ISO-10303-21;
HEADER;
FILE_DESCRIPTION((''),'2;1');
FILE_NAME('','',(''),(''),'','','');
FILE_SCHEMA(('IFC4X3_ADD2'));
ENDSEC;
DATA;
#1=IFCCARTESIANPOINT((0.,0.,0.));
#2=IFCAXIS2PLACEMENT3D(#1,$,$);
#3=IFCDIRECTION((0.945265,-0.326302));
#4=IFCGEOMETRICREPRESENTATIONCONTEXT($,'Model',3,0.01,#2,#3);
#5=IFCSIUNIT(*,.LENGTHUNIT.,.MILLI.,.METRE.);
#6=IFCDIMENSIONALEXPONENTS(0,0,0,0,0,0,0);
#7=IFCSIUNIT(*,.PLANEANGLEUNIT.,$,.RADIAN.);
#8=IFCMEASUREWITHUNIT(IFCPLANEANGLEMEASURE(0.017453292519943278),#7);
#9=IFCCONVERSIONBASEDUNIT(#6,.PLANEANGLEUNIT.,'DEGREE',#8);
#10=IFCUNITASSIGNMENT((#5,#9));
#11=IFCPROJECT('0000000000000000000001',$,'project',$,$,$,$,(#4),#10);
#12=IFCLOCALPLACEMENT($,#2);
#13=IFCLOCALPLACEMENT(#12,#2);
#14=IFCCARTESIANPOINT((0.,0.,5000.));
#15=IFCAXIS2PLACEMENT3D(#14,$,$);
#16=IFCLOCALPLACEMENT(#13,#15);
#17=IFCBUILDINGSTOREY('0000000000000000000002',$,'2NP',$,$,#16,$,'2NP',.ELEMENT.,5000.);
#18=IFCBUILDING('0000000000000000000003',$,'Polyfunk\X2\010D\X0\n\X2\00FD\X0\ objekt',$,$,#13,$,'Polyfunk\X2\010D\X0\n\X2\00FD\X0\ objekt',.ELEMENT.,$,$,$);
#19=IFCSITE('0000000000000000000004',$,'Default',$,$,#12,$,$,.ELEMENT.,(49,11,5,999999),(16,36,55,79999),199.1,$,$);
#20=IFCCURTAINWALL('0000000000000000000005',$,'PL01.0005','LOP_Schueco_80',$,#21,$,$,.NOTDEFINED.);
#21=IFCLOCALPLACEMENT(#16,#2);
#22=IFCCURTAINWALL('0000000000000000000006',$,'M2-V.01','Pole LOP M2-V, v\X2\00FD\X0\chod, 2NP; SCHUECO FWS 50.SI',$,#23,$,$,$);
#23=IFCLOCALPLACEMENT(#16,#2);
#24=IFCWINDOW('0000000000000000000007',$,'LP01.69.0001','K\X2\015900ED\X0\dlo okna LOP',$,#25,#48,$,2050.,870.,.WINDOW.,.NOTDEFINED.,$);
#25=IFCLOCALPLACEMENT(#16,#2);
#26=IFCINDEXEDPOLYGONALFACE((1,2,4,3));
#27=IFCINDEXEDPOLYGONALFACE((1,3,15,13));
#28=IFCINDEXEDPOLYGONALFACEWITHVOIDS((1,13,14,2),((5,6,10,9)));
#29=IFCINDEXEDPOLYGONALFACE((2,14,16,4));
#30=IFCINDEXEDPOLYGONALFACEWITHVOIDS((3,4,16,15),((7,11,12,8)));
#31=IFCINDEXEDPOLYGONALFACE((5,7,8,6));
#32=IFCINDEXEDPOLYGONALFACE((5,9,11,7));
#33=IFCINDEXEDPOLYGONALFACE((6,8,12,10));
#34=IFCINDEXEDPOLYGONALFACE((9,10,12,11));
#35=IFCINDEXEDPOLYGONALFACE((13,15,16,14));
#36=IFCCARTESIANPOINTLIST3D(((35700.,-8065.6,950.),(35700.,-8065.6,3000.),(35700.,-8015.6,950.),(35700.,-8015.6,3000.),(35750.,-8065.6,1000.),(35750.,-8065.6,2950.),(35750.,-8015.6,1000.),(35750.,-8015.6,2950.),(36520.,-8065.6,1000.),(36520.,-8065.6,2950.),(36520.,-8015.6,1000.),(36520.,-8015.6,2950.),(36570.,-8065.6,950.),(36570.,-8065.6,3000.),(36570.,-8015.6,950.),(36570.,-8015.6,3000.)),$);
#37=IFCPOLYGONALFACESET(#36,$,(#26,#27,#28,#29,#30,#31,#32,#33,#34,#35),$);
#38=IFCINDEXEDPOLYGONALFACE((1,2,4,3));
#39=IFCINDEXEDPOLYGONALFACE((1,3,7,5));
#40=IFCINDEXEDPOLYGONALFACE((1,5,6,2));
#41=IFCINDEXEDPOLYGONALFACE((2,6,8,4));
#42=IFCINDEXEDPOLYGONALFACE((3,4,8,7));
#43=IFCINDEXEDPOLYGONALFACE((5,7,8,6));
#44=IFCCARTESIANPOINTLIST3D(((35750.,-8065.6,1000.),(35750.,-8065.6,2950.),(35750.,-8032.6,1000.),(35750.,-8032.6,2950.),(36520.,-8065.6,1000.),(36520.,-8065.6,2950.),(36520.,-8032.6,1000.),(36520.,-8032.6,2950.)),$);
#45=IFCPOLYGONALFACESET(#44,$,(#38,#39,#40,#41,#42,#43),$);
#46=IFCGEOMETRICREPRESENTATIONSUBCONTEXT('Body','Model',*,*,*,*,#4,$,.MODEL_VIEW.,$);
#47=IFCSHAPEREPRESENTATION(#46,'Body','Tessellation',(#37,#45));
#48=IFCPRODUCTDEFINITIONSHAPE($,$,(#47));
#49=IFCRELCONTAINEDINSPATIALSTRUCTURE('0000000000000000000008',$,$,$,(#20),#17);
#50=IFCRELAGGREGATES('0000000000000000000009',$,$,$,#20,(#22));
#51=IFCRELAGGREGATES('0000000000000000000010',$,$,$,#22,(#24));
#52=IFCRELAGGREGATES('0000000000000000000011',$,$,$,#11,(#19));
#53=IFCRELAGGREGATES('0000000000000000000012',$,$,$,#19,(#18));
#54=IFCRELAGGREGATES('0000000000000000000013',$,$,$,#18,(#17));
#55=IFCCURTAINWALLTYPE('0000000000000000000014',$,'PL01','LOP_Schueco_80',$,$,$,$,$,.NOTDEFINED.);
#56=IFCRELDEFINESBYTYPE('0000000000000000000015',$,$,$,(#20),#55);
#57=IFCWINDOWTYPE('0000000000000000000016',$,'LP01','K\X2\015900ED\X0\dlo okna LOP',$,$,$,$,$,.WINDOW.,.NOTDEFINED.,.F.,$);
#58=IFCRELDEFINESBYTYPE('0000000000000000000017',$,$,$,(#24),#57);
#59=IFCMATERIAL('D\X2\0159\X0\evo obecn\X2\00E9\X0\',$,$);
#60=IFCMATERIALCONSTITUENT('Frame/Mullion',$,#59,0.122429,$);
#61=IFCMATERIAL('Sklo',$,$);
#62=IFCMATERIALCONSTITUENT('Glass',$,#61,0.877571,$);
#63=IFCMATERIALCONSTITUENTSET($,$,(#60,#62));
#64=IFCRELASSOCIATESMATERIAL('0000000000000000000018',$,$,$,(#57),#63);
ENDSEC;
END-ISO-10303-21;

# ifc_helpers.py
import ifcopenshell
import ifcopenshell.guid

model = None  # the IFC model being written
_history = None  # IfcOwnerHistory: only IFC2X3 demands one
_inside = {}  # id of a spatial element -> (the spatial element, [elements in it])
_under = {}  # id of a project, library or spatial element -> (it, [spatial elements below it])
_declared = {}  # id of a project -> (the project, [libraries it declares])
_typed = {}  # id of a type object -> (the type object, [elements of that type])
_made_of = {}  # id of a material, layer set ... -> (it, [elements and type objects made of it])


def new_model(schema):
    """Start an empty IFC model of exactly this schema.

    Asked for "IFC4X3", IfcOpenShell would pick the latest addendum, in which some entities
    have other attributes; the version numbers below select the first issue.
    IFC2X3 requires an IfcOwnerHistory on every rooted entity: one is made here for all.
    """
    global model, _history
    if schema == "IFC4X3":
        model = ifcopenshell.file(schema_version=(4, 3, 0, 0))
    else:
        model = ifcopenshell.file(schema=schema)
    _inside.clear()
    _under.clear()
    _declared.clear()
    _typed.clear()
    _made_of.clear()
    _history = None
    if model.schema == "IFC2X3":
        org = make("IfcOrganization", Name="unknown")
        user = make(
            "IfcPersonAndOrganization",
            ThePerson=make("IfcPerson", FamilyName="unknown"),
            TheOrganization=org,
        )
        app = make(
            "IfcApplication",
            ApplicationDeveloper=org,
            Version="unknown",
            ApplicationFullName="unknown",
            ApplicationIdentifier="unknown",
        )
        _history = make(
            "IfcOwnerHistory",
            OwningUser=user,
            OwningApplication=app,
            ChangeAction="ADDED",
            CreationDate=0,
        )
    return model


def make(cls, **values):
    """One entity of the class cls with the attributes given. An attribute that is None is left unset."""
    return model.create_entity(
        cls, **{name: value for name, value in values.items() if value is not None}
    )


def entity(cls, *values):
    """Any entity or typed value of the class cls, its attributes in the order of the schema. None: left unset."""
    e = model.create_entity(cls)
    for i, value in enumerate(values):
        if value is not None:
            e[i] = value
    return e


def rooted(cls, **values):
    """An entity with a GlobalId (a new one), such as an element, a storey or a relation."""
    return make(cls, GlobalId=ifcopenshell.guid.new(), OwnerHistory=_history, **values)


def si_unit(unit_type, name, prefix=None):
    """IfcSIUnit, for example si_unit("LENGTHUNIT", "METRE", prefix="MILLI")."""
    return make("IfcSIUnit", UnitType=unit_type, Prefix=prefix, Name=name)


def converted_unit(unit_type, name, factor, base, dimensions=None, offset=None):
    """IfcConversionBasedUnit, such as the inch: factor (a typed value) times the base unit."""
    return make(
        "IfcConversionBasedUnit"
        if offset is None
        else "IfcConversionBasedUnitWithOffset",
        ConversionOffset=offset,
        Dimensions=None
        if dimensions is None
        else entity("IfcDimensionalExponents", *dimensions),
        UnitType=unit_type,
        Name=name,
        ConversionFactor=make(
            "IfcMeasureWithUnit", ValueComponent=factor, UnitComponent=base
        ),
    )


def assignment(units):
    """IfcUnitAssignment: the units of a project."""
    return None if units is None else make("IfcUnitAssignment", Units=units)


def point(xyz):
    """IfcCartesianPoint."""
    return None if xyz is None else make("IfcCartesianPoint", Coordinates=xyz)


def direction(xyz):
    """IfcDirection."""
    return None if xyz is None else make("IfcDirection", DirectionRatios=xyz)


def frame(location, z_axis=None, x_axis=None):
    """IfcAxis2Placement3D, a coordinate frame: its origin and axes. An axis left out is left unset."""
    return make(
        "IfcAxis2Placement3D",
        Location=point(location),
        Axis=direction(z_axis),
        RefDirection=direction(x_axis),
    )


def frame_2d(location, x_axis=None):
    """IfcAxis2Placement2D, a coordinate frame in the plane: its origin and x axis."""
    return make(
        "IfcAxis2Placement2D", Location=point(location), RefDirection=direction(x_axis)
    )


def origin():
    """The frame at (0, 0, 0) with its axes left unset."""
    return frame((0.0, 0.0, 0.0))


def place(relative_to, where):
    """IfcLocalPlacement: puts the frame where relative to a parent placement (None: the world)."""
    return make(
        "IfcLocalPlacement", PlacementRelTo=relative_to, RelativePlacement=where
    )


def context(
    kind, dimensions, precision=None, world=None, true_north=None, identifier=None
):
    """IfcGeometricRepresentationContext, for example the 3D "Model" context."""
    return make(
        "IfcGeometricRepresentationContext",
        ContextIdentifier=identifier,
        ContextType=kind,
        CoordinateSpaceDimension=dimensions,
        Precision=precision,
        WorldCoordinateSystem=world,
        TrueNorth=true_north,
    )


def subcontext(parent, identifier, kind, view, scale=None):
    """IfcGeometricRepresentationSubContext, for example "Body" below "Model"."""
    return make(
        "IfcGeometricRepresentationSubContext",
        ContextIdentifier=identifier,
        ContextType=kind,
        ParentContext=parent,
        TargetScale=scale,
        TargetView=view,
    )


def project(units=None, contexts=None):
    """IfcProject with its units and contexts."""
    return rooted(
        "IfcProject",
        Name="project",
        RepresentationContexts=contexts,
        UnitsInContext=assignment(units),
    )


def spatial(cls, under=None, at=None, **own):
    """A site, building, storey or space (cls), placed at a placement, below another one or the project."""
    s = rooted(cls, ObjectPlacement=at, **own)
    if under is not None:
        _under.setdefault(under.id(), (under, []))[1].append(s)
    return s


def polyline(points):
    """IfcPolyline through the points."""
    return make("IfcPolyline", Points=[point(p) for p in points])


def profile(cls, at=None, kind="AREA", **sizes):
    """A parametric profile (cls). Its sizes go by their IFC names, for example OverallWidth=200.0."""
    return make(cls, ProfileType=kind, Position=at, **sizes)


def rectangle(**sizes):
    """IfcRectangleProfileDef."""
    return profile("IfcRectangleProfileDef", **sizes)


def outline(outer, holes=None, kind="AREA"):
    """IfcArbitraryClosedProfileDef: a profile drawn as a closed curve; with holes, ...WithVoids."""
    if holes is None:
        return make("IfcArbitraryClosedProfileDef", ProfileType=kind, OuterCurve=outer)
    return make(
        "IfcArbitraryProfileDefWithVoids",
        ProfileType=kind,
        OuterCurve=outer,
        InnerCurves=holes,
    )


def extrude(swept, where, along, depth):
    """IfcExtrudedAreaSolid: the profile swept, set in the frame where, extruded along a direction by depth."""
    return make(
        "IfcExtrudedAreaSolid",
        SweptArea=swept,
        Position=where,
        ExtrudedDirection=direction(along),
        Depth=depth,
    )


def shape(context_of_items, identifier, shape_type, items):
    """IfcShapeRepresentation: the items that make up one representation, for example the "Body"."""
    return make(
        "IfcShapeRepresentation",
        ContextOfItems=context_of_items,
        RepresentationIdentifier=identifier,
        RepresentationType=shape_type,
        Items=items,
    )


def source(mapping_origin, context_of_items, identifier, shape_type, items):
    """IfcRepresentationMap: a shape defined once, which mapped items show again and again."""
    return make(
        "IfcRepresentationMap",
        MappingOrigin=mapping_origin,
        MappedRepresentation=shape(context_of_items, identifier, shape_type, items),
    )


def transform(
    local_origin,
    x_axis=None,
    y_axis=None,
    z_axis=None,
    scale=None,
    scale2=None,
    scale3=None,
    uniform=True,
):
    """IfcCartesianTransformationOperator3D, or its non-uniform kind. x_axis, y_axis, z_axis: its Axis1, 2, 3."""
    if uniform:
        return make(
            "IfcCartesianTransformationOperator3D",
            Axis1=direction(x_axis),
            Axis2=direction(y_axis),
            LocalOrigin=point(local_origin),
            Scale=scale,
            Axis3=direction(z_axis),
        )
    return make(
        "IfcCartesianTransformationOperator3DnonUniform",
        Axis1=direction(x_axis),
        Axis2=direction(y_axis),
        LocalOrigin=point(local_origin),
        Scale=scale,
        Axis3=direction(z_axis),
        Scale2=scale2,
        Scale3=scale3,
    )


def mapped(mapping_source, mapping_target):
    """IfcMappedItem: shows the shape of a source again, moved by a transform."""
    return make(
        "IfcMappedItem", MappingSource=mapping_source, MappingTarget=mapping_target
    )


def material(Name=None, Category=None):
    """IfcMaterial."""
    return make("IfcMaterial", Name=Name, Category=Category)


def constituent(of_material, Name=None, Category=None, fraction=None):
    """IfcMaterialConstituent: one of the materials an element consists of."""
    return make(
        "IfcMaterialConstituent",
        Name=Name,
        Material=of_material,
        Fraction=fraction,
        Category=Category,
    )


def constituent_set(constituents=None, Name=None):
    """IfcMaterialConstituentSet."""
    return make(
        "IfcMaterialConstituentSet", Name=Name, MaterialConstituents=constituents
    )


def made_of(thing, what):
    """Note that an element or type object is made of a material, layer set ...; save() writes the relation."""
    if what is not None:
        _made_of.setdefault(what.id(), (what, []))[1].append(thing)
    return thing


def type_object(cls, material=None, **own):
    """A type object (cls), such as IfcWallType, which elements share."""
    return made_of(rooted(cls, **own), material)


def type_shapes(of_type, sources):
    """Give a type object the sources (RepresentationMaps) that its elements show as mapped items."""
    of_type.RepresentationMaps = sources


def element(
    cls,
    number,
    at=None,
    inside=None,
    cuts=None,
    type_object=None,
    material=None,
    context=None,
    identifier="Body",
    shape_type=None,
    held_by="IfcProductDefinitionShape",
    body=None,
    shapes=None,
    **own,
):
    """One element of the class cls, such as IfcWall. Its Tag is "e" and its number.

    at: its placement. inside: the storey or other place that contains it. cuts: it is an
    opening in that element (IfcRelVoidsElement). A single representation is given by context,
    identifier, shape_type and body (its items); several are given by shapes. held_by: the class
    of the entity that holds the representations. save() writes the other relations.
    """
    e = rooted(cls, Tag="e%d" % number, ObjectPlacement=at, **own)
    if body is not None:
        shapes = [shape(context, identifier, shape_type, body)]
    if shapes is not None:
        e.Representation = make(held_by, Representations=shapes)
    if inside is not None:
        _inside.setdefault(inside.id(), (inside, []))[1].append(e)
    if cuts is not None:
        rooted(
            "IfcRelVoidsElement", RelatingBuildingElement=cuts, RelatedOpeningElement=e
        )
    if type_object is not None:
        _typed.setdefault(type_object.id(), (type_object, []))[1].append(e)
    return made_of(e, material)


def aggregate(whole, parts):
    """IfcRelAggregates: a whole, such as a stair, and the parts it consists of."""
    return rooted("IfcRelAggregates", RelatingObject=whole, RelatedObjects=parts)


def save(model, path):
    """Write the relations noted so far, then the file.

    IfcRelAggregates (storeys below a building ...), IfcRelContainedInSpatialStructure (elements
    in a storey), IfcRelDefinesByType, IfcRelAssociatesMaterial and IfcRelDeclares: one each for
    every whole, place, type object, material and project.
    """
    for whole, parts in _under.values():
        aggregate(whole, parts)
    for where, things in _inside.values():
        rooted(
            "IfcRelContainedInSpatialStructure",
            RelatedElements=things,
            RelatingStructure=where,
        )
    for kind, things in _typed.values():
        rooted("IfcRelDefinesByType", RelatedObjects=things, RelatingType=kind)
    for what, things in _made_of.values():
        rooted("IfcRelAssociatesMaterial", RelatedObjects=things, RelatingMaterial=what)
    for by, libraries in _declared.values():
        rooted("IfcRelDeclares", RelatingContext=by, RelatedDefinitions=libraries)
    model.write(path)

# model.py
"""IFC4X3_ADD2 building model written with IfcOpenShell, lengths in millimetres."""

from ifc_helpers import new_model, entity, si_unit, converted_unit, direction, frame, frame_2d, origin, place, context, subcontext, project, spatial, polyline, rectangle, outline, extrude, source, transform, mapped, material, constituent, constituent_set, type_object, type_shapes, element, aggregate, save


model = new_model("IFC4X3_ADD2")

# Units and contexts
model_context = context("Model", 3, precision=0.01, world=origin(), true_north=direction((0.945265, -0.326302)))
body_context = subcontext(model_context, "Body", "Model", "MODEL_VIEW")
ifc_project = project(units=[si_unit("LENGTHUNIT", "METRE", prefix="MILLI"), converted_unit("PLANEANGLEUNIT", "DEGREE", entity("IfcPlaneAngleMeasure", 0.017453292519943278), si_unit("PLANEANGLEUNIT", "RADIAN"), dimensions=[0, 0, 0, 0, 0, 0, 0])], contexts=[model_context])

# Site, building, storey
site_placement = place(None, origin())
site = spatial("IfcSite", under=ifc_project, at=site_placement, Name="Default", CompositionType="ELEMENT", RefLatitude=(49, 11, 5, 999999), RefLongitude=(16, 36, 55, 79999), RefElevation=199.1)
building_placement = place(site_placement, origin())
building = spatial("IfcBuilding", under=site, at=building_placement, Name="Polyfunkčný objekt", LongName="Polyfunkčný objekt", CompositionType="ELEMENT")
storey_placement = place(building_placement, frame((0.0, 0.0, 5000.0)))
storey = spatial("IfcBuildingStorey", under=building, at=storey_placement, Name="2NP", LongName="2NP", CompositionType="ELEMENT", Elevation=5000.0)

# Curtain walls
curtain_wall_type = type_object("IfcCurtainWallType", Name="PL01", Description="LOP_Schueco_80", PredefinedType="NOTDEFINED")
curtain_wall_1_placement = place(storey_placement, frame((0.0, 0.0, -5000.0)))
curtain_wall_1 = element("IfcCurtainWall", 1, at=curtain_wall_1_placement, inside=storey, type_object=curtain_wall_type, Name="PL01.0005", Description="LOP_Schueco_80", PredefinedType="NOTDEFINED")
curtain_wall_2 = element("IfcCurtainWall", 2, Name="M2-V.01", Description="Pole LOP M2-V, východ, 2NP; SCHUECO FWS 50.SI")
aggregate(curtain_wall_1, [curtain_wall_2])
ifc_material_1 = material(Name="Sklo")

# Window
ifc_material_2 = material(Name="Dřevo obecné")
ifc_constituent_1 = constituent(ifc_material_2, Name="Frame/Mullion", fraction=0.122429)
ifc_constituent_2 = constituent(ifc_material_1, Name="Glass", fraction=0.877571)
ifc_constituent_set = constituent_set(constituents=[ifc_constituent_1, ifc_constituent_2])
window_type = type_object("IfcWindowType", Name="LP01", Description="Křídlo okna LOP", ParameterTakesPrecedence=False, PartitioningType="NOTDEFINED", PredefinedType="WINDOW", material=ifc_constituent_set)
shared_shape_1 = source(origin(), body_context, "Body", "SweptSolid", [
    extrude(outline(polyline([(-1025.0, -435.0), (1025.0, -435.0), (1025.0, 435.0), (-1025.0, 435.0), (-1025.0, -435.0)]), holes=[polyline([(-975.0, -385.0), (-975.0, 385.0), (975.0, 385.0), (975.0, -385.0), (-975.0, -385.0)])]), frame((0.0, 50.0, 1025.0), z_axis=(0.0, -1.0, 0.0), x_axis=(0.0, 0.0, -1.0)), (0.0, 0.0, 1.0), 50.0),
    extrude(rectangle(XDim=770.0, YDim=33.0, at=frame_2d((0.0, 0.0), x_axis=(1.0, 0.0))), frame((0.0, 33.5, 50.0), z_axis=(0.0, 0.0, 1.0), x_axis=(-1.0, 0.0, 0.0)), (0.0, 0.0, 1.0), 1950.0),
])
type_shapes(window_type, [shared_shape_1])
window_placement = place(curtain_wall_1_placement, frame((36135.0, -8015.6, 5950.0), z_axis=(0.0, 0.0, 1.0), x_axis=(-1.0, 0.0, 0.0)))
window = element("IfcWindow", 3, at=window_placement, type_object=window_type, Name="LP01.69.0001", Description="Křídlo okna LOP", OverallHeight=2050.0, OverallWidth=870.0, PartitioningType="NOTDEFINED", PredefinedType="WINDOW", context=body_context, shape_type="MappedRepresentation", body=[
    mapped(shared_shape_1, transform((0.0, 0.0, 0.0), scale=1.0)),
])
aggregate(curtain_wall_2, [window])

save(model, "model.ifc")
